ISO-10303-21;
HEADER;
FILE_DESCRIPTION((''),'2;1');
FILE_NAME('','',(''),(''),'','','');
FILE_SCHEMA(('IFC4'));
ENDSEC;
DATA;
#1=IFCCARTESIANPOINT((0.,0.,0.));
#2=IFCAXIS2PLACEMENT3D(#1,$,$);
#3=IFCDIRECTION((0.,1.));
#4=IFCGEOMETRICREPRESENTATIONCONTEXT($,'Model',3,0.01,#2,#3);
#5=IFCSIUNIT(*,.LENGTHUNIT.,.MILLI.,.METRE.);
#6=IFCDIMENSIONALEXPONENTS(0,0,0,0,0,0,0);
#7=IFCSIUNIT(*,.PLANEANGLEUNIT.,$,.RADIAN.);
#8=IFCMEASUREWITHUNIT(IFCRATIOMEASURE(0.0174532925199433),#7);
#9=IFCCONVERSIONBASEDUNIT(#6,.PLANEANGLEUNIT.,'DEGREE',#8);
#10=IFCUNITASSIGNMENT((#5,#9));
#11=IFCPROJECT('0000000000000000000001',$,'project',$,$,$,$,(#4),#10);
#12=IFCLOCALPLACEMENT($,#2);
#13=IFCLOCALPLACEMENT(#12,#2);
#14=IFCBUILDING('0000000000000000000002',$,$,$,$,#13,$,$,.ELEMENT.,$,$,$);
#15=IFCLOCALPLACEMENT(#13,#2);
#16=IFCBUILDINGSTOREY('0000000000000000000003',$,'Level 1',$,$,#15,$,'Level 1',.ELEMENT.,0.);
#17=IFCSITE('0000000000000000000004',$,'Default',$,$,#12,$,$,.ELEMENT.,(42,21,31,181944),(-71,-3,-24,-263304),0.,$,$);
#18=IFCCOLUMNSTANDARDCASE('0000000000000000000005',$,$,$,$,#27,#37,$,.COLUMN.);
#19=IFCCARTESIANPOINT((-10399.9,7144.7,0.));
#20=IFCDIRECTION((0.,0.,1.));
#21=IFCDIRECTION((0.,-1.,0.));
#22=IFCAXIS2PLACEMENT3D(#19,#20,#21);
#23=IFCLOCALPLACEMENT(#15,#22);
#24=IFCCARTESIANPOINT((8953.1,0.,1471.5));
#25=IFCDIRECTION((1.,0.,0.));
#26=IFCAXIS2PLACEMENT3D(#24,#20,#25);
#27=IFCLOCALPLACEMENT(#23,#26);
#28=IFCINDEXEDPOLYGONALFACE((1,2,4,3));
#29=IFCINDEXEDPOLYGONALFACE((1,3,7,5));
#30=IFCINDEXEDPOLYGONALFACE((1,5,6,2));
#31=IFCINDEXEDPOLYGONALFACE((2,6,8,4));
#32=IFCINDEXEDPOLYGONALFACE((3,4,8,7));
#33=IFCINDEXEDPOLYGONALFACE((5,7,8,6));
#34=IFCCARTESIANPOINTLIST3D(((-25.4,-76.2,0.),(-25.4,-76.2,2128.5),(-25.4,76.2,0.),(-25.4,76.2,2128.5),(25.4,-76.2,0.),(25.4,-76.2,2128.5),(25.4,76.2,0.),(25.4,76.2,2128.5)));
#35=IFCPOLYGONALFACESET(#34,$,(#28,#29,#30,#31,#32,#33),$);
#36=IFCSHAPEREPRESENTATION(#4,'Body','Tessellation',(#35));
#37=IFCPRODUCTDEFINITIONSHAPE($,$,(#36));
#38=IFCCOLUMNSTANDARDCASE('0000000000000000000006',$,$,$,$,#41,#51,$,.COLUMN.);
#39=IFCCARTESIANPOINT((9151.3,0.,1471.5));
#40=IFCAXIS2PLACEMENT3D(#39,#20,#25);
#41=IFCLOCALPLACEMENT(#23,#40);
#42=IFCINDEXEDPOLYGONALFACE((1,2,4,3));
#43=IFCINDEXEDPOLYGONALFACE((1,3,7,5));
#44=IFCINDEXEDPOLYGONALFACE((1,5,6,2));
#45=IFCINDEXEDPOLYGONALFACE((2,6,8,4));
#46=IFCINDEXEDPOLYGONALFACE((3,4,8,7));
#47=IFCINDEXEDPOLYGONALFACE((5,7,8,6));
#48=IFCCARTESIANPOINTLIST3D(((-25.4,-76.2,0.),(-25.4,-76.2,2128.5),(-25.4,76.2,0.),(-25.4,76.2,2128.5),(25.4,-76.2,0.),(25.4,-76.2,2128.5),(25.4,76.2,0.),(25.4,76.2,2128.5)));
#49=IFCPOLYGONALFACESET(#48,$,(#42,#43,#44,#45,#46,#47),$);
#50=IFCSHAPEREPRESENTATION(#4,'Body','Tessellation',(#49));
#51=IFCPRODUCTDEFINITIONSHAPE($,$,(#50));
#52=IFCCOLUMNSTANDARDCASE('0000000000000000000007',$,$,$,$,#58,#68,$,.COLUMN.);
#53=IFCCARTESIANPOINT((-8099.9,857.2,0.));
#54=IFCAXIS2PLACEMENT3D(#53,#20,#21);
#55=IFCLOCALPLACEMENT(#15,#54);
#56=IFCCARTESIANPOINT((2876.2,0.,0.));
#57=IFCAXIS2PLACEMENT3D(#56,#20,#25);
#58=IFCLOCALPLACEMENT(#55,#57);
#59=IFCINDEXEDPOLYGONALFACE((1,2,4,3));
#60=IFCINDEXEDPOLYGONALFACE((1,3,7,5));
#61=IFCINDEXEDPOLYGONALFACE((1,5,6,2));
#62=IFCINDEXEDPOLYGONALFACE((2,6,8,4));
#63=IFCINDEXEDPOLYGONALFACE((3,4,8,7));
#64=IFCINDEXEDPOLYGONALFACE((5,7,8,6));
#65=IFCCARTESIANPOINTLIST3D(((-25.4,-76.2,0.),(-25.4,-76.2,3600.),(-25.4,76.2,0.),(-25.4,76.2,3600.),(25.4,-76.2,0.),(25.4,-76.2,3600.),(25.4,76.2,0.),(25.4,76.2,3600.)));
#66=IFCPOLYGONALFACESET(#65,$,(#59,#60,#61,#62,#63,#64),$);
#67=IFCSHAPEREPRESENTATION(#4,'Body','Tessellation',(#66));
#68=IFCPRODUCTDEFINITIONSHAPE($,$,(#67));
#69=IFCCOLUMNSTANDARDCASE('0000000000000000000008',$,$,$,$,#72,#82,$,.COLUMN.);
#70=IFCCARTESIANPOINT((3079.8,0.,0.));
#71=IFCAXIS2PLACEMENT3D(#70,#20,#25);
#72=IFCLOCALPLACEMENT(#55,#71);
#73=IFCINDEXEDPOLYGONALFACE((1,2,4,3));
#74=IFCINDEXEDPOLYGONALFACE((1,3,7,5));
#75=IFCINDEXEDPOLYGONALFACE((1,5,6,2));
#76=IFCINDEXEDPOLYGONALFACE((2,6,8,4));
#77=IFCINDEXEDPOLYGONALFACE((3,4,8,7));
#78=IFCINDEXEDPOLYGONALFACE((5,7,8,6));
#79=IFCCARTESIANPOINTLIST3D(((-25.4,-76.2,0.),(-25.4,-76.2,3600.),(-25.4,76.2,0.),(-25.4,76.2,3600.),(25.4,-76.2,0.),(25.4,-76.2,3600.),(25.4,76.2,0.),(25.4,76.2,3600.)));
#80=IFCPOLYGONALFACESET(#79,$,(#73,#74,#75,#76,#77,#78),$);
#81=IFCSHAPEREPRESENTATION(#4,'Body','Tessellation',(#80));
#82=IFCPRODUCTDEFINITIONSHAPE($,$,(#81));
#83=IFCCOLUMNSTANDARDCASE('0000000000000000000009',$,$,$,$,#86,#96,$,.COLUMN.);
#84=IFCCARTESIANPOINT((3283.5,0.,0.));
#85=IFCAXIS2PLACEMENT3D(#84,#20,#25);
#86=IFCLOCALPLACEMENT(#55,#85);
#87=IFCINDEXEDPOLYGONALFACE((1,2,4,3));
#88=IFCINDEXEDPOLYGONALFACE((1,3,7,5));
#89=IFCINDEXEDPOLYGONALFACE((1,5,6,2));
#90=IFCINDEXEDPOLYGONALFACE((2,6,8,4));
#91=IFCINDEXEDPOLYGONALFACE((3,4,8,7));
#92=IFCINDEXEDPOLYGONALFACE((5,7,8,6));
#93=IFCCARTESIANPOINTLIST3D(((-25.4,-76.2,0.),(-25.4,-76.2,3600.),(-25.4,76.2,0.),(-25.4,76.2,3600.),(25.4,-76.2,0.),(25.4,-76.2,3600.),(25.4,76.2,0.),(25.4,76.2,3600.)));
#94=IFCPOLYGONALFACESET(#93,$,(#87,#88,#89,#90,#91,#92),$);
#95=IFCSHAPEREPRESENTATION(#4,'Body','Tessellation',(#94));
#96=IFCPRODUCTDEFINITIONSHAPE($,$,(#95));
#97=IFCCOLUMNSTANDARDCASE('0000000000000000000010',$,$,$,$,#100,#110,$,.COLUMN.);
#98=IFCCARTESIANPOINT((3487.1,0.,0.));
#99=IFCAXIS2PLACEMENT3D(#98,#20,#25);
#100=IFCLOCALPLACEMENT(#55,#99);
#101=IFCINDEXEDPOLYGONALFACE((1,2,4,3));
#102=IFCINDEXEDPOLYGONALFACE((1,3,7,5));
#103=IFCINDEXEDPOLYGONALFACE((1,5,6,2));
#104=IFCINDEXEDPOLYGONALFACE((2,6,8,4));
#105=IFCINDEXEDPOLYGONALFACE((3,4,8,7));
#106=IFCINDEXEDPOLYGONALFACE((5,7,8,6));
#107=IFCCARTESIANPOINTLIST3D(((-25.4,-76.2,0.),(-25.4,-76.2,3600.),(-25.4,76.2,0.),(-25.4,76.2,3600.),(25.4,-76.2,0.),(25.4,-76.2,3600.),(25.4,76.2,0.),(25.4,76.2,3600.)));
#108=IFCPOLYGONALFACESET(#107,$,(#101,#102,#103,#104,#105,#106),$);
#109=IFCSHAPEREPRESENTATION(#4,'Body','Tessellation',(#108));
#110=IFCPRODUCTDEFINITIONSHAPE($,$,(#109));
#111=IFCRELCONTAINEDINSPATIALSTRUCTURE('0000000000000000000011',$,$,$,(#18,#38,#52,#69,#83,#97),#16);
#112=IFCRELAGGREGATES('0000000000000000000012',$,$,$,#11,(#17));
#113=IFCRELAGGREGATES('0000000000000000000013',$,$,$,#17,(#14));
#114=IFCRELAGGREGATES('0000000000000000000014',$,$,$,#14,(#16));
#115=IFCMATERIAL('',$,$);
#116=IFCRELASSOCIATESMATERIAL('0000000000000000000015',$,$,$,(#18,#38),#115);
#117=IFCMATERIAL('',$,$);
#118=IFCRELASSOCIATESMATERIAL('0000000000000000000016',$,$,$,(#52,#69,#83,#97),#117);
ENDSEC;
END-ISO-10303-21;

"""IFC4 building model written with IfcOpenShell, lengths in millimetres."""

from ifc_helpers import new_model, entity, si_unit, converted_unit, direction, frame, origin, place, context, project, spatial, rectangle, extrude, material, element, save


model = new_model("IFC4")

# Units and contexts
model_context = context("Model", 3, precision=0.01, world=origin(), true_north=direction((0.0, 1.0)))
ifc_project = project(units=[si_unit("LENGTHUNIT", "METRE", prefix="MILLI"), converted_unit("PLANEANGLEUNIT", "DEGREE", entity("IfcRatioMeasure", 0.0174532925199433), si_unit("PLANEANGLEUNIT", "RADIAN"), dimensions=[0, 0, 0, 0, 0, 0, 0])], contexts=[model_context])

# Site, building, storey
site_placement = place(None, origin())
site = spatial("IfcSite", under=ifc_project, at=site_placement, Name="Default", CompositionType="ELEMENT", RefLatitude=(42, 21, 31, 181944), RefLongitude=(-71, -3, -24, -263304), RefElevation=0.0)
building_placement = place(site_placement, origin())
building = spatial("IfcBuilding", under=site, at=building_placement, CompositionType="ELEMENT")
storey_placement = place(building_placement, origin())
storey = spatial("IfcBuildingStorey", under=building, at=storey_placement, Name="Level 1", LongName="Level 1", CompositionType="ELEMENT", Elevation=0.0)

# Columns
ifc_material_1 = material(Name="")
placement_1 = place(storey_placement, frame((-10399.9, 7144.7, 0.0), z_axis=(0.0, 0.0, 1.0), x_axis=(0.0, -1.0, 0.0)))
ifc_material_2 = material(Name="")
for number, where, z_axis, x_axis in (
    (1, (8953.1, 0.0, 1471.5), (0.0, 0.0, 1.0), (1.0, 0.0, 0.0)),
    (2, (9151.3, 0.0, 1471.5), (0.0, 0.0, 1.0), (1.0, 0.0, 0.0)),
):
    element("IfcColumnStandardCase", number, at=place(placement_1, frame(where, z_axis=z_axis, x_axis=x_axis)), inside=storey, material=ifc_material_2, PredefinedType="COLUMN", context=model_context, shape_type="SweptSolid", body=[
        extrude(rectangle(XDim=50.8, YDim=152.4), origin(), (0.0, 0.0, 1.0), 2128.5),
    ])
placement_2 = place(storey_placement, frame((-8099.9, 857.2, 0.0), z_axis=(0.0, 0.0, 1.0), x_axis=(0.0, -1.0, 0.0)))
for number, where, z_axis, x_axis in (
    (3, (2876.2, 0.0, 0.0), (0.0, 0.0, 1.0), (1.0, 0.0, 0.0)),
    (4, (3079.8, 0.0, 0.0), (0.0, 0.0, 1.0), (1.0, 0.0, 0.0)),
    (5, (3283.5, 0.0, 0.0), (0.0, 0.0, 1.0), (1.0, 0.0, 0.0)),
    (6, (3487.1, 0.0, 0.0), (0.0, 0.0, 1.0), (1.0, 0.0, 0.0)),
):
    element("IfcColumnStandardCase", number, at=place(placement_2, frame(where, z_axis=z_axis, x_axis=x_axis)), inside=storey, material=ifc_material_1, PredefinedType="COLUMN", context=model_context, shape_type="SweptSolid", body=[
        extrude(rectangle(XDim=50.8, YDim=152.4), origin(), (0.0, 0.0, 1.0), 3600.0),
    ])

save(model, "model.ifc")
